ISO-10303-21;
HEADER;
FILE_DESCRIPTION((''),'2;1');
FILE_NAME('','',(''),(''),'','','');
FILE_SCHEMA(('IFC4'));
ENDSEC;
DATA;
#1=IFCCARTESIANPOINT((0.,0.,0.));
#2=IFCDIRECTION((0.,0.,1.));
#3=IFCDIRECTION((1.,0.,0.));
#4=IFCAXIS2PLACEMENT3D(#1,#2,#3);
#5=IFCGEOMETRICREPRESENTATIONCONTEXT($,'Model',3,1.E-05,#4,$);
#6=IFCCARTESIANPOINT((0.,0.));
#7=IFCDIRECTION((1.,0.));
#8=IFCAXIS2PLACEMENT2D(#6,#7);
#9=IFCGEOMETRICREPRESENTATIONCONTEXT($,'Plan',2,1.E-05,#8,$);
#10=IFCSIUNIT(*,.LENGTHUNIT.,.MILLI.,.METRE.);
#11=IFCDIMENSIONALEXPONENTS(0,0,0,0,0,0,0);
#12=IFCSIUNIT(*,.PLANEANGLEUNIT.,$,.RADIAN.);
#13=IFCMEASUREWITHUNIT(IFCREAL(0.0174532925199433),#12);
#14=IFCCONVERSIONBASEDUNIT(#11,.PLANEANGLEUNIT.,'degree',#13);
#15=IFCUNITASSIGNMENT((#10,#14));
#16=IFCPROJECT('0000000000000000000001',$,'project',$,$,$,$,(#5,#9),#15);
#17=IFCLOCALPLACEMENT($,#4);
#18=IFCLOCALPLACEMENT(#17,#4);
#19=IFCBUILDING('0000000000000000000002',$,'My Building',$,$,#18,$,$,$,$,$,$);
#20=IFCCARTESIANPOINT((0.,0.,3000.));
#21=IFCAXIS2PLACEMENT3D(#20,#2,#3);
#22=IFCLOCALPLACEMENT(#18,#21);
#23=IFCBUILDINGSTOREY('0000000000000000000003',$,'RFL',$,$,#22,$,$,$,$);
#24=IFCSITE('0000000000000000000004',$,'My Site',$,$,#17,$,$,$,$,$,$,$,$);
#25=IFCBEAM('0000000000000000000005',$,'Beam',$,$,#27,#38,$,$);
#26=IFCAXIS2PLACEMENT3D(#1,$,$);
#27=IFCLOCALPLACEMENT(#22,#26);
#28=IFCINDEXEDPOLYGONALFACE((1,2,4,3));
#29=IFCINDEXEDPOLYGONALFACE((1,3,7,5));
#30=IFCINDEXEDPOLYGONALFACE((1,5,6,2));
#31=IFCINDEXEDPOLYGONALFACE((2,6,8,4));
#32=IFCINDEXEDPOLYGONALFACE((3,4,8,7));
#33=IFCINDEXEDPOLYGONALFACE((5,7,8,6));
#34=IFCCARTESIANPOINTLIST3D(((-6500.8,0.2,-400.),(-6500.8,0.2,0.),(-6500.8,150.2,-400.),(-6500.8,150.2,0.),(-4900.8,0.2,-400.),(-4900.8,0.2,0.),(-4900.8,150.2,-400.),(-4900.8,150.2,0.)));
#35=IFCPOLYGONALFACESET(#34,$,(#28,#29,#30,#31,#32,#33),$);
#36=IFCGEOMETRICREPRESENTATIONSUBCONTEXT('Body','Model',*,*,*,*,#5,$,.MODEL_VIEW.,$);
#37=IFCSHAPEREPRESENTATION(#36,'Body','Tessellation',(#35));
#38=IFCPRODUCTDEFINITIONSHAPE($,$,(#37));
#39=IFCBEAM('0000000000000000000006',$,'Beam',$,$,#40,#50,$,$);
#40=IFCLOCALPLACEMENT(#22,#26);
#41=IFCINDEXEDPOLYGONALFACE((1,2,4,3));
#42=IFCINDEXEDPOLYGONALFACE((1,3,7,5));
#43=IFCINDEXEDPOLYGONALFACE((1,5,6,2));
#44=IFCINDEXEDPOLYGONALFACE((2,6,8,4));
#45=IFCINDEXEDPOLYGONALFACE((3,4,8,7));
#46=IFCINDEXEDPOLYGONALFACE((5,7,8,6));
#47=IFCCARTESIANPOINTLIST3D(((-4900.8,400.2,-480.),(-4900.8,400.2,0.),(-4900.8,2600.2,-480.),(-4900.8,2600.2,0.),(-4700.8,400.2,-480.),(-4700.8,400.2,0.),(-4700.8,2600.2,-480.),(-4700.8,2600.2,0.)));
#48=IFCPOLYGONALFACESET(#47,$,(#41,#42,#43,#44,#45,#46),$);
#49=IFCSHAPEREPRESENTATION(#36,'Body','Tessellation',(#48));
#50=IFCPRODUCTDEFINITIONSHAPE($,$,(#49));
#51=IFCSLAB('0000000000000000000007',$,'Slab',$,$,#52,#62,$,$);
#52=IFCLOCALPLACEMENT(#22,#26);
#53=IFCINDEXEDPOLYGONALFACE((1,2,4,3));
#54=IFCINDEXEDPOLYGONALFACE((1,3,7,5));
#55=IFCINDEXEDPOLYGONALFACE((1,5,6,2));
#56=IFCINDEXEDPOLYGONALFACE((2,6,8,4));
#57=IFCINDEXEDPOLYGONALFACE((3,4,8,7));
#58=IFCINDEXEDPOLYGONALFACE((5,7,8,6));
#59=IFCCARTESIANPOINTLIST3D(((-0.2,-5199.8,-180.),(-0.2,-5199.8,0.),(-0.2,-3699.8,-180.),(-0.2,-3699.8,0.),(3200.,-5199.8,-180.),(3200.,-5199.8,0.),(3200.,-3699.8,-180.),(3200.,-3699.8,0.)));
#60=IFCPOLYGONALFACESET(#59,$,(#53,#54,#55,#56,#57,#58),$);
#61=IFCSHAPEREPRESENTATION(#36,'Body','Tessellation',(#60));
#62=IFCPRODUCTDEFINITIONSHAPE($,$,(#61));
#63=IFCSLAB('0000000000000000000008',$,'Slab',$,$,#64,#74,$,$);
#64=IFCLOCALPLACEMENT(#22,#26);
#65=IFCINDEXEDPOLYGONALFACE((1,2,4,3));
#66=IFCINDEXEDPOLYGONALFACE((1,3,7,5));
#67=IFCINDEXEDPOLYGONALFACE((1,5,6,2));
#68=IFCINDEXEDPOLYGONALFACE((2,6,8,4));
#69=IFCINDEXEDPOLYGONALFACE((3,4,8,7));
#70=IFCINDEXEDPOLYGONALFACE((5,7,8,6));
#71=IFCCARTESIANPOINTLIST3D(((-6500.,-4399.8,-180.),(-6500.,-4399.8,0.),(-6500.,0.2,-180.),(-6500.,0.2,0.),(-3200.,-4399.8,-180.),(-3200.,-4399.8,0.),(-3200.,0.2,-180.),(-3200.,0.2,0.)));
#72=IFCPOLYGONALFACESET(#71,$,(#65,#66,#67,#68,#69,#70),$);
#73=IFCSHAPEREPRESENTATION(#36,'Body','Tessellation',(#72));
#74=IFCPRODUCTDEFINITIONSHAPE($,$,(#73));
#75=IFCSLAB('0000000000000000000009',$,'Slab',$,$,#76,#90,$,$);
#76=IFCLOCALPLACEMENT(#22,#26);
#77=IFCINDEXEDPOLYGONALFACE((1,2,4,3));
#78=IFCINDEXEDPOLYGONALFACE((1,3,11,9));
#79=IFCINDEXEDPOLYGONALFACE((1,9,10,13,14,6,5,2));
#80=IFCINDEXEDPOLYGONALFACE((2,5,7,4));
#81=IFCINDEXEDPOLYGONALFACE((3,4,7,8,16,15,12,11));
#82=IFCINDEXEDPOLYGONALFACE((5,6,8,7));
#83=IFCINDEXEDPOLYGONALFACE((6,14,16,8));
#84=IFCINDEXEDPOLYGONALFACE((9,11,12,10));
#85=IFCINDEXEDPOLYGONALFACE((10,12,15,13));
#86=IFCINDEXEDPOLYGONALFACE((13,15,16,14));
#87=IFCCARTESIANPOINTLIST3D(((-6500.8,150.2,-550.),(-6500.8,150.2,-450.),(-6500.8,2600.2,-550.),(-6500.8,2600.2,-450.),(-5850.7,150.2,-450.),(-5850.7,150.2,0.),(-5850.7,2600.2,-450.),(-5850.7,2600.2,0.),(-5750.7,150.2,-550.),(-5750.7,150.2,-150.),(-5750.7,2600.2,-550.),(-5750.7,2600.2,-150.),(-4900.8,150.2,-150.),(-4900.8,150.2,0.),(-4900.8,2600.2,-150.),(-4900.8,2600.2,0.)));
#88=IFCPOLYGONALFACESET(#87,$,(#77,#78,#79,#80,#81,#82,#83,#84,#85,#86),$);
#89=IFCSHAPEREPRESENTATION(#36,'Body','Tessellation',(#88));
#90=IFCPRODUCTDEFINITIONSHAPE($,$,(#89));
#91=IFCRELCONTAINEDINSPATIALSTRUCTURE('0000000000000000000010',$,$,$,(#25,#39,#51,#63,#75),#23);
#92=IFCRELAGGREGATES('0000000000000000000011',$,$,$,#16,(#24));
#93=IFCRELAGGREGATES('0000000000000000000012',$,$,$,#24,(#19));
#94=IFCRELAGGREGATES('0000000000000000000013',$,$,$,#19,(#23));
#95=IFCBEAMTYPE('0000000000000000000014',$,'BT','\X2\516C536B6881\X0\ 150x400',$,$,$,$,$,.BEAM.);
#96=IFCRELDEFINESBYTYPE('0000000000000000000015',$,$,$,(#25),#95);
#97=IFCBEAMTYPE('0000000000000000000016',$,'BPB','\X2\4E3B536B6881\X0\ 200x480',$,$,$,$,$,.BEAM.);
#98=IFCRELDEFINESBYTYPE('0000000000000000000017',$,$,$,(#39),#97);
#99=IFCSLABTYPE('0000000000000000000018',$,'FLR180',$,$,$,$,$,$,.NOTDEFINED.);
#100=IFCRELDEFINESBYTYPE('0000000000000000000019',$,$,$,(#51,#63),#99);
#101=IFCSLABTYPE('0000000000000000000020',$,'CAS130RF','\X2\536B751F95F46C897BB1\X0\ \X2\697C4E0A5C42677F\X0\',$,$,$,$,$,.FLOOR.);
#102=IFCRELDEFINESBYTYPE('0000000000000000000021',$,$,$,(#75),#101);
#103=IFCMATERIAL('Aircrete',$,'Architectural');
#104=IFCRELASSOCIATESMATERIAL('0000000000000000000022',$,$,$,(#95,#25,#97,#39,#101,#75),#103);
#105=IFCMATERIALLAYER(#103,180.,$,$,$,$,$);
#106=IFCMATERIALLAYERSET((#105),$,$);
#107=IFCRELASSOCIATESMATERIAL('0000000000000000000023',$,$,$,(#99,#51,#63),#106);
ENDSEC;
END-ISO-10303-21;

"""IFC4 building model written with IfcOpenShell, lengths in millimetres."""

from ifc_helpers import new_model, entity, si_unit, converted_unit, frame, origin_with_axes, origin_2d_with_axis, place, context, subcontext, project, spatial, indexed_curve, rectangle, outline, extrude, material, layer, layer_set, layer_usage, material_profile, profile_set, profile_usage, type_object, element, save


model = new_model("IFC4")

# Units and contexts
model_context = context("Model", 3, precision=1e-05, world=origin_with_axes())
plan_context = context("Plan", 2, precision=1e-05, world=origin_2d_with_axis())
body_context = subcontext(model_context, "Body", "Model", "MODEL_VIEW")
ifc_project = project(units=[si_unit("LENGTHUNIT", "METRE", prefix="MILLI"), converted_unit("PLANEANGLEUNIT", "degree", entity("IfcReal", 0.0174532925199433), si_unit("PLANEANGLEUNIT", "RADIAN"), dimensions=[0, 0, 0, 0, 0, 0, 0])], contexts=[model_context, plan_context])

# Site, building, storey
site_placement = place(None, origin_with_axes())
site = spatial("IfcSite", under=ifc_project, at=site_placement, Name="My Site")
building_placement = place(site_placement, origin_with_axes())
building = spatial("IfcBuilding", under=site, at=building_placement, Name="My Building")
storey_placement = place(building_placement, frame((0.0, 0.0, 3000.0), z_axis=(0.0, 0.0, 1.0), x_axis=(1.0, 0.0, 0.0)))
storey = spatial("IfcBuildingStorey", under=building, at=storey_placement, Name="RFL")

# Beams
ifc_material = material(Name="Aircrete", Category="Architectural")
ifc_material_profile_1 = material_profile(ifc_material, rectangle(XDim=150.0, YDim=400.0))
ifc_profile_set_1 = profile_set([ifc_material_profile_1])
ifc_profile_usage_1 = profile_usage(ifc_profile_set_1, cardinal=9)
beam_type_1 = type_object("IfcBeamType", Name="BT", Description="公卫梁 150x400", PredefinedType="BEAM", material=ifc_profile_set_1)
beam_1_placement = place(storey_placement, frame((-4900.8, 150.2, 0.0), z_axis=(-1.0, 0.0, 0.0), x_axis=(0.0, -1.0, 0.0)))
element("IfcBeam", 1, at=beam_1_placement, inside=storey, type_object=beam_type_1, material=ifc_profile_usage_1, Name="Beam", context=body_context, shape_type="SweptSolid", body=[
    extrude(rectangle(XDim=150.0, YDim=400.0), frame((75.0, -200.0, 0.0), z_axis=(0.0, 0.0, 1.0), x_axis=(1.0, 0.0, 0.0)), (0.0, 0.0, 1.0), 1600.0),
])
ifc_material_profile_2 = material_profile(ifc_material, rectangle(XDim=200.0, YDim=480.0))
ifc_profile_set_2 = profile_set([ifc_material_profile_2])
ifc_profile_usage_2 = profile_usage(ifc_profile_set_2, cardinal=9)
beam_type_2 = type_object("IfcBeamType", Name="BPB", Description="主卫梁 200x480", PredefinedType="BEAM", material=ifc_profile_set_2)
beam_2_placement = place(storey_placement, frame((-4900.8, 2600.2, 0.0), z_axis=(0.0, -1.0, 0.0), x_axis=(1.0, 0.0, 0.0)))
element("IfcBeam", 2, at=beam_2_placement, inside=storey, type_object=beam_type_2, material=ifc_profile_usage_2, Name="Beam", context=body_context, shape_type="SweptSolid", body=[
    extrude(rectangle(XDim=200.0, YDim=480.0), frame((100.0, -240.0, 0.0), z_axis=(0.0, 0.0, 1.0), x_axis=(1.0, 0.0, 0.0)), (0.0, 0.0, 1.0), 2200.0),
])

# Slabs
ifc_layer_1 = layer(ifc_material, 180.0)
ifc_layer_set_1 = layer_set([ifc_layer_1])
ifc_layer_usage_1 = layer_usage(ifc_layer_set_1, "AXIS3", "POSITIVE", 0.0)
slab_type_1 = type_object("IfcSlabType", Name="FLR180", PredefinedType="NOTDEFINED", material=ifc_layer_set_1)
slab_1_placement = place(storey_placement, frame((0.0, -3699.8, 0.0), z_axis=(0.0, 0.0, -1.0), x_axis=(1.0, 0.0, 0.0)))
element("IfcSlab", 3, at=slab_1_placement, inside=storey, type_object=slab_type_1, material=ifc_layer_usage_1, Name="Slab", context=body_context, shape_type="SweptSolid", body=[
    extrude(outline(indexed_curve([(-0.2, 1500.0), (3200.0, 1500.0), (3200.0, 0.0), (-0.2, 0.0), (-0.2, 1500.0)])), None, (0.0, 0.0, 1.0), 180.0),
])
ifc_layer_usage_2 = layer_usage(ifc_layer_set_1, "AXIS3", "POSITIVE", 0.0)
slab_2_placement = place(storey_placement, frame((-6500.0, -4399.8, -180.0), z_axis=(0.0, 0.0, 1.0), x_axis=(1.0, 0.0, 0.0)))
element("IfcSlab", 4, at=slab_2_placement, inside=storey, type_object=slab_type_1, material=ifc_layer_usage_2, Name="Slab", context=body_context, shape_type="SweptSolid", body=[
    extrude(outline(indexed_curve([(0.0, 4400.0), (3300.0, 4400.0), (3300.0, 0.0), (0.0, 0.0), (0.0, 4400.0)])), None, (0.0, 0.0, 1.0), 180.0),
])

# Shared definitions
ifc_material_profile_3 = material_profile(ifc_material, outline(indexed_curve([(950.0, -450.0), (1600.0, -450.0), (1600.0, -550.0), (850.0, -550.0), (850.0, -150.0), (0.0, -150.0), (0.0, 0.0), (950.0, 0.0), (950.0, -450.0)])))
ifc_profile_set_3 = profile_set([ifc_material_profile_3])
slab_type_2 = type_object("IfcSlabType", Name="CAS130RF", Description="卫生间沉箱 楼上层板", PredefinedType="FLOOR", material=ifc_profile_set_3)

# Slab
ifc_profile_usage_3 = profile_usage(ifc_profile_set_3)
slab_3_placement = place(storey_placement, frame((-4900.8, 150.2, 0.0), z_axis=(0.0, 1.0, 0.0), x_axis=(-1.0, 0.0, 0.0)))
element("IfcSlab", 5, at=slab_3_placement, inside=storey, type_object=slab_type_2, material=ifc_profile_usage_3, Name="Slab", context=body_context, shape_type="SweptSolid", body=[
    extrude(outline(indexed_curve([(950.0, -450.0), (1600.0, -450.0), (1600.0, -550.0), (850.0, -550.0), (850.0, -150.0), (0.0, -150.0), (0.0, 0.0), (950.0, 0.0), (950.0, -450.0)])), origin_with_axes(), (0.0, 0.0, 1.0), 2450.0),
])

save(model, "model.ifc")
